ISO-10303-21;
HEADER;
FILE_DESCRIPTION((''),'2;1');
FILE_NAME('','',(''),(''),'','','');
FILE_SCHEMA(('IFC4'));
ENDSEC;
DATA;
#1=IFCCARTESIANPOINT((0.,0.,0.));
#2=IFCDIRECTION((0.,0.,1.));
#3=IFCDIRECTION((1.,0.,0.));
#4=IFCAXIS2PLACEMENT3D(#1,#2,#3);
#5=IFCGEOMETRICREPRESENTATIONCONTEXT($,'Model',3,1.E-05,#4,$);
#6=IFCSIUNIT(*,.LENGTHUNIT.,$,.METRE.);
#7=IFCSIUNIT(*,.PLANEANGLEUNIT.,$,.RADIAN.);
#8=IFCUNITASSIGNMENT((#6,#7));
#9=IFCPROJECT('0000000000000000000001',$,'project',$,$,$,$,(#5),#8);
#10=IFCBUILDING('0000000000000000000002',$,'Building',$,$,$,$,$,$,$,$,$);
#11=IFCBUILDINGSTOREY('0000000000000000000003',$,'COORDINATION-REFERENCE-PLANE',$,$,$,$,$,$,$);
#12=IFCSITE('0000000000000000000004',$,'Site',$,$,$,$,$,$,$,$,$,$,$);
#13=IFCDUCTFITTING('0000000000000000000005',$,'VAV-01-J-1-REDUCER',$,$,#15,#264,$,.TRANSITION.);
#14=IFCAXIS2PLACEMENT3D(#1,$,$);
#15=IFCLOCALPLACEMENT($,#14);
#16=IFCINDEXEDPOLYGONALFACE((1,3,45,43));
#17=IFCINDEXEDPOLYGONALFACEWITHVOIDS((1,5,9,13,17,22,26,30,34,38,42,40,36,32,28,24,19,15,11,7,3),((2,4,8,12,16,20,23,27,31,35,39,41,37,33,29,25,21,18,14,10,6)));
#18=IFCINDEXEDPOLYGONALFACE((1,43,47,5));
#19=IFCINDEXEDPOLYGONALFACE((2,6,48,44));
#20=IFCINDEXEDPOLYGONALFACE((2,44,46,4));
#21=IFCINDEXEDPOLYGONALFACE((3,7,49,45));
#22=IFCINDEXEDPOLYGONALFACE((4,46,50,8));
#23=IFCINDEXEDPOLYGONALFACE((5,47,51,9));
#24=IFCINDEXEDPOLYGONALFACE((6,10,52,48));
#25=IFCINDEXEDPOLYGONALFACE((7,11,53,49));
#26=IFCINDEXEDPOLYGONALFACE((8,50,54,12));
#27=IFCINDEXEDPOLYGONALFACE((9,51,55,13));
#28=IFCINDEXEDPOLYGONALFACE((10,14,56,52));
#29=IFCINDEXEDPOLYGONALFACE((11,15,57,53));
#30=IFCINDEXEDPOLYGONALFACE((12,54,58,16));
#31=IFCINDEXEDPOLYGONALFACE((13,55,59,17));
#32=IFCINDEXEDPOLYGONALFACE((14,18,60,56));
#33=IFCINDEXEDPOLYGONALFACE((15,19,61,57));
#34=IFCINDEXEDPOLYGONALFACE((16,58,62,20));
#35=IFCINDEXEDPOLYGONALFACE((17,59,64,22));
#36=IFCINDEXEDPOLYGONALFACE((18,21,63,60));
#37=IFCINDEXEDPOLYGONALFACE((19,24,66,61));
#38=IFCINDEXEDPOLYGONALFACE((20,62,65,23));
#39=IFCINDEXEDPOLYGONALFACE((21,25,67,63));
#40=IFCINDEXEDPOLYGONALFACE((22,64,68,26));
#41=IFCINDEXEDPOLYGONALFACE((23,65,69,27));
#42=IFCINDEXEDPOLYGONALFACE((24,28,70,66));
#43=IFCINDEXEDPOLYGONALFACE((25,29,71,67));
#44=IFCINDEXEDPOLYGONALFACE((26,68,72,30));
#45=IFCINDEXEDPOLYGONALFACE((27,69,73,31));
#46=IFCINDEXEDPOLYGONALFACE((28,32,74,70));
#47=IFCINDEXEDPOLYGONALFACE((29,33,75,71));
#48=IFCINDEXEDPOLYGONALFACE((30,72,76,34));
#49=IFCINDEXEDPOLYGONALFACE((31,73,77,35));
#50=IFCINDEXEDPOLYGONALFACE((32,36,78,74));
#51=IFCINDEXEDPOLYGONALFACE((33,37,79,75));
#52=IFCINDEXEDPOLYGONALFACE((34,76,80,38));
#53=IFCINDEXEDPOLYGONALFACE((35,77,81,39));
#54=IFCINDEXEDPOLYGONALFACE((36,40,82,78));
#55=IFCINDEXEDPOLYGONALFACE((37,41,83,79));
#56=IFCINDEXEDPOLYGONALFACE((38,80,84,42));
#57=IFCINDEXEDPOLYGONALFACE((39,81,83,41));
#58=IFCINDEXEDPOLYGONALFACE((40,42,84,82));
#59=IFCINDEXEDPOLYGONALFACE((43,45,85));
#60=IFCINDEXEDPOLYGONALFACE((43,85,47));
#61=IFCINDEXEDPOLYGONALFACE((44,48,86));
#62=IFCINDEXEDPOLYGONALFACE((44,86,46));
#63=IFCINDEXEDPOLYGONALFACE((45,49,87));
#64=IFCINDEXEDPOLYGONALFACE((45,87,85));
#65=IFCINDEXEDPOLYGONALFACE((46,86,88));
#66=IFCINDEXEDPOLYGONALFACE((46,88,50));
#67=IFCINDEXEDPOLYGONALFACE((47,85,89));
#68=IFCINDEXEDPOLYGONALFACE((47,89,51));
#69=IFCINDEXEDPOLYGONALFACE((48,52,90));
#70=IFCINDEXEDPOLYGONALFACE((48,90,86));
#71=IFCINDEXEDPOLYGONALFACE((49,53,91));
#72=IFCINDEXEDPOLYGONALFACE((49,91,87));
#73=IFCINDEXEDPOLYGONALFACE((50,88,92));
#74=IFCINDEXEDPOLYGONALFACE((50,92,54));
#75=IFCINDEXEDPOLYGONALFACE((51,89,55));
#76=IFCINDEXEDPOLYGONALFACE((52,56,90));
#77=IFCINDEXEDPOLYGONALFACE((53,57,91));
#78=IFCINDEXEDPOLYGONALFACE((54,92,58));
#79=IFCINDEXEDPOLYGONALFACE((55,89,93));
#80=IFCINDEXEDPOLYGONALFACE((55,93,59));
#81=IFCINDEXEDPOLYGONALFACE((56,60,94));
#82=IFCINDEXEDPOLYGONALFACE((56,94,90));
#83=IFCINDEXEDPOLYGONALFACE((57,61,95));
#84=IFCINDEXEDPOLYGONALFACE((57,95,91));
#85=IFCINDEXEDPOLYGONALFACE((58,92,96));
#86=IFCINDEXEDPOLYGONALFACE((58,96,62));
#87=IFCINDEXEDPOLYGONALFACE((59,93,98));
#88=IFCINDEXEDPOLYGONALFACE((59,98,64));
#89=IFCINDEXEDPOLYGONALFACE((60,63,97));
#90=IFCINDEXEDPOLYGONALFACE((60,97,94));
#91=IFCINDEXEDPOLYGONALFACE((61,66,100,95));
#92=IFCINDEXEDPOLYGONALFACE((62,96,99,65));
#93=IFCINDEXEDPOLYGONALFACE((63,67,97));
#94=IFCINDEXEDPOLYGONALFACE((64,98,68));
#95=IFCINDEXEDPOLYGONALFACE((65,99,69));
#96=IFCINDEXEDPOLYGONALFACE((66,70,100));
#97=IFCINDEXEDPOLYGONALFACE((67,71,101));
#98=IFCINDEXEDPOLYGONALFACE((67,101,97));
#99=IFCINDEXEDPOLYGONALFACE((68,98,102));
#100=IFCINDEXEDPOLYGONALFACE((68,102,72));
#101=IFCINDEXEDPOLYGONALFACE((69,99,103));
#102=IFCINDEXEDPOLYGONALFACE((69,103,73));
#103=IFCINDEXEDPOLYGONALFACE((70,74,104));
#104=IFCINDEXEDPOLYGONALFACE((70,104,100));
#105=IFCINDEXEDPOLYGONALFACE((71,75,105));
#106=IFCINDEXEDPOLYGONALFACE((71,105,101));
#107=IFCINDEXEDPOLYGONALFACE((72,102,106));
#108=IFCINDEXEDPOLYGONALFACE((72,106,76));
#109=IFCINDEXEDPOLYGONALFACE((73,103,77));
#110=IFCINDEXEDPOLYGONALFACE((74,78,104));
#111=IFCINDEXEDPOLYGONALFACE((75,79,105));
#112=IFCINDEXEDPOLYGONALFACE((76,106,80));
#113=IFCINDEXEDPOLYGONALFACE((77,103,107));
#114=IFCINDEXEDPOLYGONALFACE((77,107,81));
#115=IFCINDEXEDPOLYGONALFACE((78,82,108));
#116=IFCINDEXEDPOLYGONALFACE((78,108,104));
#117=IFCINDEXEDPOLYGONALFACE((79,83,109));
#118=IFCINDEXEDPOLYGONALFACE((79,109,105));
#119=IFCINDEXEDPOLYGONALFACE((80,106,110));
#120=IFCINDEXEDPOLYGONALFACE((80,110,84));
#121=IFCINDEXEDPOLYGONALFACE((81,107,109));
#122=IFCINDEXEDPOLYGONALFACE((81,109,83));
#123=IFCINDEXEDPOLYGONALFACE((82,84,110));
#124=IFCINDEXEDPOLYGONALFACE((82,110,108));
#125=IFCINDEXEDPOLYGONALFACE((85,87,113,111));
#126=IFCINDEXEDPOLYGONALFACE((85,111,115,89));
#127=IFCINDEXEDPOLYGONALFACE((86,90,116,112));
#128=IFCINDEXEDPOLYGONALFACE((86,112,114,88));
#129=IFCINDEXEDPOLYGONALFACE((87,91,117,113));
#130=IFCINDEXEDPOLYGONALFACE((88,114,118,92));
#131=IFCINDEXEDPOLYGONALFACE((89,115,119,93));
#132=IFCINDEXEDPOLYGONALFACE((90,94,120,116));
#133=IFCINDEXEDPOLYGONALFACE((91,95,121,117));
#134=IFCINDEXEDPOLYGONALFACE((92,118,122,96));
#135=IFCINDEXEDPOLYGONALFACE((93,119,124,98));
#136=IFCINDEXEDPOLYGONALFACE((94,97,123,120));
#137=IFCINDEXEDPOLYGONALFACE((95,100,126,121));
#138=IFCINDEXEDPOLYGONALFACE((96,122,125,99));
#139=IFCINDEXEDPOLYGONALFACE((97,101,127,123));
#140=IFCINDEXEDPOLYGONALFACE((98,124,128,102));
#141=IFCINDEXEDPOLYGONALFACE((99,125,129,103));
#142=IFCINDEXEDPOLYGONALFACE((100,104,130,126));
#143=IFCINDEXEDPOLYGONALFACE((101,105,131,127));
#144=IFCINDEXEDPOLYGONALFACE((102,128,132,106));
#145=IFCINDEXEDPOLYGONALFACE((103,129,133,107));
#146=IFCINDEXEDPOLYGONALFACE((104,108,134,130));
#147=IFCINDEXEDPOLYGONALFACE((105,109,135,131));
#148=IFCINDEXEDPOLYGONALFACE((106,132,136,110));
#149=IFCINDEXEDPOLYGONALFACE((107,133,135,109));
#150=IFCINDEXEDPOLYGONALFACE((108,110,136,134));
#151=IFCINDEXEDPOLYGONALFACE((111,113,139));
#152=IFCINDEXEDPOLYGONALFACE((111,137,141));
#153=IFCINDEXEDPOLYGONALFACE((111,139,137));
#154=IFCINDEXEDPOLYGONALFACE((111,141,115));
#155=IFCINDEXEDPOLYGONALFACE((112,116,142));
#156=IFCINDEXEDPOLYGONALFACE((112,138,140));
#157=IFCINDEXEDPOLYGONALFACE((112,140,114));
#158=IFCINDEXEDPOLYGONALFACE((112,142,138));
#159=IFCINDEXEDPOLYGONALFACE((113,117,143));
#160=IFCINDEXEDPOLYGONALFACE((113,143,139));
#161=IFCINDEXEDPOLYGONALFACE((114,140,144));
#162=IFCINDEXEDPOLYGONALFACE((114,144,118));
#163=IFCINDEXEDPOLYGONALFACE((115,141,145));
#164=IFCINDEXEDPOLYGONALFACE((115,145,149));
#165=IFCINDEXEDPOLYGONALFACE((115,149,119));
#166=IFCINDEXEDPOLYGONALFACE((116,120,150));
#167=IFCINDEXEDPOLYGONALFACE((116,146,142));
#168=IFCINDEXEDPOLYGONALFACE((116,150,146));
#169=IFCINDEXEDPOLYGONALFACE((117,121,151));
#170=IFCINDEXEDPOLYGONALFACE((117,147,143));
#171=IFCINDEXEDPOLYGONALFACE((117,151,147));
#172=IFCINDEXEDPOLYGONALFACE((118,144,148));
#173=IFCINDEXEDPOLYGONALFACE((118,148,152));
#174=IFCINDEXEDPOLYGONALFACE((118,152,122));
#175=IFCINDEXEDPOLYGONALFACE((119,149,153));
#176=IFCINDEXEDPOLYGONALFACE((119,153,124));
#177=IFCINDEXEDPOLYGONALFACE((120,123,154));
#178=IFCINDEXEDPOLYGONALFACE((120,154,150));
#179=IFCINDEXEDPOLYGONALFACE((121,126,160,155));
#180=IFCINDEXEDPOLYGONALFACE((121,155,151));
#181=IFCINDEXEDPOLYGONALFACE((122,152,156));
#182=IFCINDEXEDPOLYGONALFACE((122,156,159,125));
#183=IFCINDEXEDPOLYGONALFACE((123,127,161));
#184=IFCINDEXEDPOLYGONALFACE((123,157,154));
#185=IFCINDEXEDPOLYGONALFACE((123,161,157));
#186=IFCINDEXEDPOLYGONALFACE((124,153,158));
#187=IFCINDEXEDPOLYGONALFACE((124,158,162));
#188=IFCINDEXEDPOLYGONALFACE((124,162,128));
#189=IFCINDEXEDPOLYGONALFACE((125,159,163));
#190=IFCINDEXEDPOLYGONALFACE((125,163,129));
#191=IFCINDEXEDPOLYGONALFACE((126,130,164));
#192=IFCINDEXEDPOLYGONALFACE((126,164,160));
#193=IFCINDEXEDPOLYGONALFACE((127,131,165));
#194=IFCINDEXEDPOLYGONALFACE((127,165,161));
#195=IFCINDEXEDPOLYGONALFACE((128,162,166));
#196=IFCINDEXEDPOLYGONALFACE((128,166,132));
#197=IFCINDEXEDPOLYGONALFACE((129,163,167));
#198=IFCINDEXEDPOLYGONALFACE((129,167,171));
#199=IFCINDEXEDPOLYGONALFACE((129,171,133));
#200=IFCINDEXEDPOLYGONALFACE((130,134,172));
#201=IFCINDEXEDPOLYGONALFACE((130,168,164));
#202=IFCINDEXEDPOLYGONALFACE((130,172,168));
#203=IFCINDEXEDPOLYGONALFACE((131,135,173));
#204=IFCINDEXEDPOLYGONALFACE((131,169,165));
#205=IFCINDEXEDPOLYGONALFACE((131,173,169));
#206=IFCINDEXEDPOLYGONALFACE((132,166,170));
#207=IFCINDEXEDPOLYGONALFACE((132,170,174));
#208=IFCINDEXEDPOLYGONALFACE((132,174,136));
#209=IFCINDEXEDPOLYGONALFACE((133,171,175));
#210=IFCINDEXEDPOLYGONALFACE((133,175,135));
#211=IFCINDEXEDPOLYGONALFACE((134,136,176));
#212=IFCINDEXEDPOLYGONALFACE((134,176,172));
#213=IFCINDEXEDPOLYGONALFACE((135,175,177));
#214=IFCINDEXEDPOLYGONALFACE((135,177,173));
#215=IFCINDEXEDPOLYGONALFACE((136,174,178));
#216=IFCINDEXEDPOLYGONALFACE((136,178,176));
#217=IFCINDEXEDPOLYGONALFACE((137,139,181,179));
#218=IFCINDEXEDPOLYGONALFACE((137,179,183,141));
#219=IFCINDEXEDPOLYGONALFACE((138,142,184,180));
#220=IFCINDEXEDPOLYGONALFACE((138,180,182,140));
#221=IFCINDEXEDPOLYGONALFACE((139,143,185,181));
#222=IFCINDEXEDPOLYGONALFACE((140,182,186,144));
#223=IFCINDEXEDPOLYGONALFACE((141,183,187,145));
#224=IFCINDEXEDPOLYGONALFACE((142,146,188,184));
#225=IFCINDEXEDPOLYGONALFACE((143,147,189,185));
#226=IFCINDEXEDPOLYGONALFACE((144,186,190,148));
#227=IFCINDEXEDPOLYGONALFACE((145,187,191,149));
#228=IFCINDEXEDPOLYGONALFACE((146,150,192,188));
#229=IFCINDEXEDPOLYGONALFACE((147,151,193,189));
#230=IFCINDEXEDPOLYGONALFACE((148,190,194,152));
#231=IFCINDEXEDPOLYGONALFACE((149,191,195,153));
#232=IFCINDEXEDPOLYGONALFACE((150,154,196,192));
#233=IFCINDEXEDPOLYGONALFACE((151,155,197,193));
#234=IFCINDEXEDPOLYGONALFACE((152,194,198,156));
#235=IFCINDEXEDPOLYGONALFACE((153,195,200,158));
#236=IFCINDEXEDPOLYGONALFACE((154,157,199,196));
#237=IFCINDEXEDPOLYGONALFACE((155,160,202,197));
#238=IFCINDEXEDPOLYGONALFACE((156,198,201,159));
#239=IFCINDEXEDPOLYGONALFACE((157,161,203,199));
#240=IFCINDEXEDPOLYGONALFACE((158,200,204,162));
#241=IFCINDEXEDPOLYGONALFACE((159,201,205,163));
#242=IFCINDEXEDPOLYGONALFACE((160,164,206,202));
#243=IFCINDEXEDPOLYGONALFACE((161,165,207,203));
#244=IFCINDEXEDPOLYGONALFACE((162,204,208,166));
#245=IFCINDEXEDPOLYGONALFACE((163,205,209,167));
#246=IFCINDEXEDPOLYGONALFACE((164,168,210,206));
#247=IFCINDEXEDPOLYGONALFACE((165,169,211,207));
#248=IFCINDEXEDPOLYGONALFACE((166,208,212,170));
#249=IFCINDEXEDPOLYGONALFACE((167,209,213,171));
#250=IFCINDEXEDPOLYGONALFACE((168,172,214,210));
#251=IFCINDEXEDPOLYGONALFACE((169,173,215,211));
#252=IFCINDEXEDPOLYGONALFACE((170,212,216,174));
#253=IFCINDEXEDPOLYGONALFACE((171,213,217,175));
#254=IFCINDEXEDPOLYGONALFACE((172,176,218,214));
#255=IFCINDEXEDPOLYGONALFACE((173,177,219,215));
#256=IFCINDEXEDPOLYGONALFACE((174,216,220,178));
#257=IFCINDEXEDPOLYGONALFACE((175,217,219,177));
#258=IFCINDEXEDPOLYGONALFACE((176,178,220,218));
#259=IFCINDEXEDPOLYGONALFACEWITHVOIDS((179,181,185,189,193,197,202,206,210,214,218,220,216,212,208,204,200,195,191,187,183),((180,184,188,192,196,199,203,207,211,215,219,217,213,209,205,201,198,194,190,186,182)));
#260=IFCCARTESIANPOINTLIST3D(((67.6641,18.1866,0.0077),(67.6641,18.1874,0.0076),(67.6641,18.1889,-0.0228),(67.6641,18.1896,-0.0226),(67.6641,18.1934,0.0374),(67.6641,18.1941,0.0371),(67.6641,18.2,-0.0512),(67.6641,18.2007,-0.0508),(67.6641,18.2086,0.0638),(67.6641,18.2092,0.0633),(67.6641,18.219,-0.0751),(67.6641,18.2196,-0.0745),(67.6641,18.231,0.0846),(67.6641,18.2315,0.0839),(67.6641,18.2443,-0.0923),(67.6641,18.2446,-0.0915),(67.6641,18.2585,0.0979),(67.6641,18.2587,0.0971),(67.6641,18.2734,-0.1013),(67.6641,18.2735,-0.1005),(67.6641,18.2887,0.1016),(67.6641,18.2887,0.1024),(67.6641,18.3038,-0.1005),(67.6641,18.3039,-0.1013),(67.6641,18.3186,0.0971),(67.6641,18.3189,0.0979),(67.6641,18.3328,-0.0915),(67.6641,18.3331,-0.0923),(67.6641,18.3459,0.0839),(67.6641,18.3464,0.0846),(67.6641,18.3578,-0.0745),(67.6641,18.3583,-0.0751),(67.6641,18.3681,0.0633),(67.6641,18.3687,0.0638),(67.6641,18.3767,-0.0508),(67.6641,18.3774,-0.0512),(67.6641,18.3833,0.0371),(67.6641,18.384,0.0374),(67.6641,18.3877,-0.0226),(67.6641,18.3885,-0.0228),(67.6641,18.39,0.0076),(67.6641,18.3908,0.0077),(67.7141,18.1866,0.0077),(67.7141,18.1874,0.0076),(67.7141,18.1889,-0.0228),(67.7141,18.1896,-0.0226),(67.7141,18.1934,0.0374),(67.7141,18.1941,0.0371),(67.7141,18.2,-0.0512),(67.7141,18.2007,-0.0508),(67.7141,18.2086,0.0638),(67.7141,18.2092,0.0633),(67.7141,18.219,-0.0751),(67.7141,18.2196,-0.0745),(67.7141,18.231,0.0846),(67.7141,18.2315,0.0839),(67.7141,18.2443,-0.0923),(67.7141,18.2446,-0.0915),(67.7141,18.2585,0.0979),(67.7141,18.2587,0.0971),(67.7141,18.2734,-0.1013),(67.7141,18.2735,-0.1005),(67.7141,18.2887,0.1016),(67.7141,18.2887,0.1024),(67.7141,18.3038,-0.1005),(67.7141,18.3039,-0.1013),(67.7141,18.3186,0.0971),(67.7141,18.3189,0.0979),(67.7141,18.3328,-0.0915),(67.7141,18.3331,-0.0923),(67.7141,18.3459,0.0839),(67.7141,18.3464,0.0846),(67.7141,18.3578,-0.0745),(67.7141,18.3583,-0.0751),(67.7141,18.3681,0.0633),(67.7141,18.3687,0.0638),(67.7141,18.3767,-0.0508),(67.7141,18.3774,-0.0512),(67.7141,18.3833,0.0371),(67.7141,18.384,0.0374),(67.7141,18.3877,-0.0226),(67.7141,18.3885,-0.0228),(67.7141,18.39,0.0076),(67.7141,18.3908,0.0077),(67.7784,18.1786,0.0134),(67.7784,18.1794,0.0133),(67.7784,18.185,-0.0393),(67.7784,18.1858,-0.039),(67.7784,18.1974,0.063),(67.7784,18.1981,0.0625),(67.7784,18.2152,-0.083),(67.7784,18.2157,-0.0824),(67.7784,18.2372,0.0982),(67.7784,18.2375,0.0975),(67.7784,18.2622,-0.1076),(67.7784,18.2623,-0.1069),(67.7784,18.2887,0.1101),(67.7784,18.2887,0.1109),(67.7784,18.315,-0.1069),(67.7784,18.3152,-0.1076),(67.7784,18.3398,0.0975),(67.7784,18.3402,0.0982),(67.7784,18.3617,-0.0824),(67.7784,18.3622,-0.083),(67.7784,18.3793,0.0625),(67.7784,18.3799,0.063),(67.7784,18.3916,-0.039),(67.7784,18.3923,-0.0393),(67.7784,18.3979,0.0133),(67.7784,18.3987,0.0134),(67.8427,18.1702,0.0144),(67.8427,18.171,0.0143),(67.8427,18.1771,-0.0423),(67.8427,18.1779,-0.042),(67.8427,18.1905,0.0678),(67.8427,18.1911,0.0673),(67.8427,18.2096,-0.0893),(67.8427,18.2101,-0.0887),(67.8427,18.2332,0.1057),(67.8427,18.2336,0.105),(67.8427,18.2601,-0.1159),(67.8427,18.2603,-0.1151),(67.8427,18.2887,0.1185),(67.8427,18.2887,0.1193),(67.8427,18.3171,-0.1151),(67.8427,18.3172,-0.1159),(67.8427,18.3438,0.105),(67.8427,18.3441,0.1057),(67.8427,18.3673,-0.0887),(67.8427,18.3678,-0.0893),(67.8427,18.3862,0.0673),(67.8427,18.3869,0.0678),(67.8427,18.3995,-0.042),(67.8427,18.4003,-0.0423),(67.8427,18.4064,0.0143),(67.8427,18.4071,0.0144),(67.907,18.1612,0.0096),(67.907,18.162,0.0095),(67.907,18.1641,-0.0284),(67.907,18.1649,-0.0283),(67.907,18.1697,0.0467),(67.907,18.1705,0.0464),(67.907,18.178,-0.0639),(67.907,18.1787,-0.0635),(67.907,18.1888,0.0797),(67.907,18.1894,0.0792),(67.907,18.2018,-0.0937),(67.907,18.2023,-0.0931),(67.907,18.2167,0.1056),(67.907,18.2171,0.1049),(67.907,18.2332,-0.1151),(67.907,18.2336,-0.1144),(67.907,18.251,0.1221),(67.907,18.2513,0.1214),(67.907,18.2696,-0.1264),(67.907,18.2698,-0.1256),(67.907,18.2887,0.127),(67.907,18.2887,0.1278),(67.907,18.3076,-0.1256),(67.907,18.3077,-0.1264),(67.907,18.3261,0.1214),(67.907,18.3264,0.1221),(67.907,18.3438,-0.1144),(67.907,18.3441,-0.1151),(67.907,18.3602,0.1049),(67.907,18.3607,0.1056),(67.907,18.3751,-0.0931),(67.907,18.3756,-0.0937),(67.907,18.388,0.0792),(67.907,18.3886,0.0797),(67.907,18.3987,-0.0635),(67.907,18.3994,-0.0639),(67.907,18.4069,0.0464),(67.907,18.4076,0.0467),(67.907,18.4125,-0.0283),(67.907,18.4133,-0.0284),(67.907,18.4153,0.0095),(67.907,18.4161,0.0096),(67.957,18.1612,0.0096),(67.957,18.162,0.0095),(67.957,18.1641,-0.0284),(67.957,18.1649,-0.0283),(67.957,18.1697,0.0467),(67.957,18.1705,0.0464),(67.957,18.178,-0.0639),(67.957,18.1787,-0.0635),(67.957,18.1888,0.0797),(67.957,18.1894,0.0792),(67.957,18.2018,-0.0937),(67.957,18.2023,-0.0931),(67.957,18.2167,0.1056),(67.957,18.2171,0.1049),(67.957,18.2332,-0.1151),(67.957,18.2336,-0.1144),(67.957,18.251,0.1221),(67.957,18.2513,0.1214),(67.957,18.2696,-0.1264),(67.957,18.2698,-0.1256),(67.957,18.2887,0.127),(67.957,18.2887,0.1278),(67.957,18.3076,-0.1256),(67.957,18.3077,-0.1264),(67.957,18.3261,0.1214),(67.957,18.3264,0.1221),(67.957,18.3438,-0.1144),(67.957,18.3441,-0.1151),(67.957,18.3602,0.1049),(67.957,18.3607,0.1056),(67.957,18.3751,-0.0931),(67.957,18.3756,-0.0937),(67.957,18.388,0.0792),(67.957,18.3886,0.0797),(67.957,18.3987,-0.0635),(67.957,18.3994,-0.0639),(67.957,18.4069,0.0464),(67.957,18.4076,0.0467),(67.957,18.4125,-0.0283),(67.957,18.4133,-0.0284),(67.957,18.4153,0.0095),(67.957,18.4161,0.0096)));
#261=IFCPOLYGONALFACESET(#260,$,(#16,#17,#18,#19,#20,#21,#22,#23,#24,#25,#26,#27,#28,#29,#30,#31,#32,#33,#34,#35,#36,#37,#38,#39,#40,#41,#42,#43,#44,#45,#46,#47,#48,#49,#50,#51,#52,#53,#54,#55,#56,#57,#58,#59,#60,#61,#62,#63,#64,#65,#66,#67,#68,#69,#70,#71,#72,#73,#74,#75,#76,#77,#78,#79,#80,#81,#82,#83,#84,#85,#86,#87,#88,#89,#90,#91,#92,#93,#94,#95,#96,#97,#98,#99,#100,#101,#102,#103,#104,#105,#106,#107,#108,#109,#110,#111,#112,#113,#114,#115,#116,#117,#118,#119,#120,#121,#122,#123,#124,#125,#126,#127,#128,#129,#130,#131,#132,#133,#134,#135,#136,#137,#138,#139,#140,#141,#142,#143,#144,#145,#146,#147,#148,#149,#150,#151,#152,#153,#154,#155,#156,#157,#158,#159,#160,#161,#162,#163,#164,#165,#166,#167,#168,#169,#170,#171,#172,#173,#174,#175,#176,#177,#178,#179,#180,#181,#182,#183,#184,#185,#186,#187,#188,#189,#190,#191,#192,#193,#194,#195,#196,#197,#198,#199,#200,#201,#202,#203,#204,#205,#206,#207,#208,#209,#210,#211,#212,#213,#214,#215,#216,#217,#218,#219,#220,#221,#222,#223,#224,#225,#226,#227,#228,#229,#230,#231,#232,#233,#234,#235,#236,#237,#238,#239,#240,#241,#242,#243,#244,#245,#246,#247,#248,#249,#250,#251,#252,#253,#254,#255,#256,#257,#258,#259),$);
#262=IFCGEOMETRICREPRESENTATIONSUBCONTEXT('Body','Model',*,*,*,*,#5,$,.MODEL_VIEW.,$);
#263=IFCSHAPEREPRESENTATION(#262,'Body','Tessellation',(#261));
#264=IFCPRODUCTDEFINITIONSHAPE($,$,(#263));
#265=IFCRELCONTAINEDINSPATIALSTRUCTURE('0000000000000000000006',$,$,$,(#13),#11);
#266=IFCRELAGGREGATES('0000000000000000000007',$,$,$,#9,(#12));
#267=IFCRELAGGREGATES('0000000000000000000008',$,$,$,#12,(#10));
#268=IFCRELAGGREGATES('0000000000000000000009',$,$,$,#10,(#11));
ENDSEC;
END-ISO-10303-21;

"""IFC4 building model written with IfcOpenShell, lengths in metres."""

from ifc_helpers import new_model, entity, si_unit, frame, origin_with_axes, place, context, subcontext, project, spatial, element, save


model = new_model("IFC4")

# Units and contexts
model_context = context("Model", 3, precision=1e-05, world=origin_with_axes())
body_context_1 = subcontext(model_context, "Body", "Model", "MODEL_VIEW")
ifc_project = project(units=[si_unit("LENGTHUNIT", "METRE"), si_unit("PLANEANGLEUNIT", "RADIAN")], contexts=[model_context])

# Site, building, storey
site = spatial("IfcSite", under=ifc_project, Name="Site")
building = spatial("IfcBuilding", under=site, Name="Building")
storey = spatial("IfcBuildingStorey", under=building, Name="COORDINATION-REFERENCE-PLANE")

# Duct fitting
for number, where, z_axis, x_axis, name in (
    (1, (67.957, 18.2887, 0.0), (0.0, -1.0, 0.0), (0.0, 0.0, 1.0), "VAV-01-J-1-REDUCER"),
):
    element("IfcDuctFitting", number, at=place(None, frame(where, z_axis=z_axis, x_axis=x_axis)), inside=storey, Name=name, PredefinedType="TRANSITION", context=body_context_1, shape_type="SweptSolid", body=[
        entity("IfcRevolvedAreaSolid", entity("IfcArbitraryClosedProfileDef", "AREA", None, entity("IfcPolyline", [entity("IfcCartesianPoint", [0.1278, 0.0]), entity("IfcCartesianPoint", [0.1278, 0.05]), entity("IfcCartesianPoint", [0.1024, 0.2429]), entity("IfcCartesianPoint", [0.1024, 0.2929]), entity("IfcCartesianPoint", [0.1016, 0.2929]), entity("IfcCartesianPoint", [0.1016, 0.2429]), entity("IfcCartesianPoint", [0.127, 0.05]), entity("IfcCartesianPoint", [0.127, 0.0]), entity("IfcCartesianPoint", [0.1278, 0.0])])), entity("IfcAxis2Placement3D", entity("IfcCartesianPoint", [0.0, 0.0, 0.0])), entity("IfcAxis1Placement", entity("IfcCartesianPoint", [0.0, 0.0, 0.0]), entity("IfcDirection", [0.0, 1.0, 0.0])), 6.283185),
    ])

save(model, "model.ifc")
